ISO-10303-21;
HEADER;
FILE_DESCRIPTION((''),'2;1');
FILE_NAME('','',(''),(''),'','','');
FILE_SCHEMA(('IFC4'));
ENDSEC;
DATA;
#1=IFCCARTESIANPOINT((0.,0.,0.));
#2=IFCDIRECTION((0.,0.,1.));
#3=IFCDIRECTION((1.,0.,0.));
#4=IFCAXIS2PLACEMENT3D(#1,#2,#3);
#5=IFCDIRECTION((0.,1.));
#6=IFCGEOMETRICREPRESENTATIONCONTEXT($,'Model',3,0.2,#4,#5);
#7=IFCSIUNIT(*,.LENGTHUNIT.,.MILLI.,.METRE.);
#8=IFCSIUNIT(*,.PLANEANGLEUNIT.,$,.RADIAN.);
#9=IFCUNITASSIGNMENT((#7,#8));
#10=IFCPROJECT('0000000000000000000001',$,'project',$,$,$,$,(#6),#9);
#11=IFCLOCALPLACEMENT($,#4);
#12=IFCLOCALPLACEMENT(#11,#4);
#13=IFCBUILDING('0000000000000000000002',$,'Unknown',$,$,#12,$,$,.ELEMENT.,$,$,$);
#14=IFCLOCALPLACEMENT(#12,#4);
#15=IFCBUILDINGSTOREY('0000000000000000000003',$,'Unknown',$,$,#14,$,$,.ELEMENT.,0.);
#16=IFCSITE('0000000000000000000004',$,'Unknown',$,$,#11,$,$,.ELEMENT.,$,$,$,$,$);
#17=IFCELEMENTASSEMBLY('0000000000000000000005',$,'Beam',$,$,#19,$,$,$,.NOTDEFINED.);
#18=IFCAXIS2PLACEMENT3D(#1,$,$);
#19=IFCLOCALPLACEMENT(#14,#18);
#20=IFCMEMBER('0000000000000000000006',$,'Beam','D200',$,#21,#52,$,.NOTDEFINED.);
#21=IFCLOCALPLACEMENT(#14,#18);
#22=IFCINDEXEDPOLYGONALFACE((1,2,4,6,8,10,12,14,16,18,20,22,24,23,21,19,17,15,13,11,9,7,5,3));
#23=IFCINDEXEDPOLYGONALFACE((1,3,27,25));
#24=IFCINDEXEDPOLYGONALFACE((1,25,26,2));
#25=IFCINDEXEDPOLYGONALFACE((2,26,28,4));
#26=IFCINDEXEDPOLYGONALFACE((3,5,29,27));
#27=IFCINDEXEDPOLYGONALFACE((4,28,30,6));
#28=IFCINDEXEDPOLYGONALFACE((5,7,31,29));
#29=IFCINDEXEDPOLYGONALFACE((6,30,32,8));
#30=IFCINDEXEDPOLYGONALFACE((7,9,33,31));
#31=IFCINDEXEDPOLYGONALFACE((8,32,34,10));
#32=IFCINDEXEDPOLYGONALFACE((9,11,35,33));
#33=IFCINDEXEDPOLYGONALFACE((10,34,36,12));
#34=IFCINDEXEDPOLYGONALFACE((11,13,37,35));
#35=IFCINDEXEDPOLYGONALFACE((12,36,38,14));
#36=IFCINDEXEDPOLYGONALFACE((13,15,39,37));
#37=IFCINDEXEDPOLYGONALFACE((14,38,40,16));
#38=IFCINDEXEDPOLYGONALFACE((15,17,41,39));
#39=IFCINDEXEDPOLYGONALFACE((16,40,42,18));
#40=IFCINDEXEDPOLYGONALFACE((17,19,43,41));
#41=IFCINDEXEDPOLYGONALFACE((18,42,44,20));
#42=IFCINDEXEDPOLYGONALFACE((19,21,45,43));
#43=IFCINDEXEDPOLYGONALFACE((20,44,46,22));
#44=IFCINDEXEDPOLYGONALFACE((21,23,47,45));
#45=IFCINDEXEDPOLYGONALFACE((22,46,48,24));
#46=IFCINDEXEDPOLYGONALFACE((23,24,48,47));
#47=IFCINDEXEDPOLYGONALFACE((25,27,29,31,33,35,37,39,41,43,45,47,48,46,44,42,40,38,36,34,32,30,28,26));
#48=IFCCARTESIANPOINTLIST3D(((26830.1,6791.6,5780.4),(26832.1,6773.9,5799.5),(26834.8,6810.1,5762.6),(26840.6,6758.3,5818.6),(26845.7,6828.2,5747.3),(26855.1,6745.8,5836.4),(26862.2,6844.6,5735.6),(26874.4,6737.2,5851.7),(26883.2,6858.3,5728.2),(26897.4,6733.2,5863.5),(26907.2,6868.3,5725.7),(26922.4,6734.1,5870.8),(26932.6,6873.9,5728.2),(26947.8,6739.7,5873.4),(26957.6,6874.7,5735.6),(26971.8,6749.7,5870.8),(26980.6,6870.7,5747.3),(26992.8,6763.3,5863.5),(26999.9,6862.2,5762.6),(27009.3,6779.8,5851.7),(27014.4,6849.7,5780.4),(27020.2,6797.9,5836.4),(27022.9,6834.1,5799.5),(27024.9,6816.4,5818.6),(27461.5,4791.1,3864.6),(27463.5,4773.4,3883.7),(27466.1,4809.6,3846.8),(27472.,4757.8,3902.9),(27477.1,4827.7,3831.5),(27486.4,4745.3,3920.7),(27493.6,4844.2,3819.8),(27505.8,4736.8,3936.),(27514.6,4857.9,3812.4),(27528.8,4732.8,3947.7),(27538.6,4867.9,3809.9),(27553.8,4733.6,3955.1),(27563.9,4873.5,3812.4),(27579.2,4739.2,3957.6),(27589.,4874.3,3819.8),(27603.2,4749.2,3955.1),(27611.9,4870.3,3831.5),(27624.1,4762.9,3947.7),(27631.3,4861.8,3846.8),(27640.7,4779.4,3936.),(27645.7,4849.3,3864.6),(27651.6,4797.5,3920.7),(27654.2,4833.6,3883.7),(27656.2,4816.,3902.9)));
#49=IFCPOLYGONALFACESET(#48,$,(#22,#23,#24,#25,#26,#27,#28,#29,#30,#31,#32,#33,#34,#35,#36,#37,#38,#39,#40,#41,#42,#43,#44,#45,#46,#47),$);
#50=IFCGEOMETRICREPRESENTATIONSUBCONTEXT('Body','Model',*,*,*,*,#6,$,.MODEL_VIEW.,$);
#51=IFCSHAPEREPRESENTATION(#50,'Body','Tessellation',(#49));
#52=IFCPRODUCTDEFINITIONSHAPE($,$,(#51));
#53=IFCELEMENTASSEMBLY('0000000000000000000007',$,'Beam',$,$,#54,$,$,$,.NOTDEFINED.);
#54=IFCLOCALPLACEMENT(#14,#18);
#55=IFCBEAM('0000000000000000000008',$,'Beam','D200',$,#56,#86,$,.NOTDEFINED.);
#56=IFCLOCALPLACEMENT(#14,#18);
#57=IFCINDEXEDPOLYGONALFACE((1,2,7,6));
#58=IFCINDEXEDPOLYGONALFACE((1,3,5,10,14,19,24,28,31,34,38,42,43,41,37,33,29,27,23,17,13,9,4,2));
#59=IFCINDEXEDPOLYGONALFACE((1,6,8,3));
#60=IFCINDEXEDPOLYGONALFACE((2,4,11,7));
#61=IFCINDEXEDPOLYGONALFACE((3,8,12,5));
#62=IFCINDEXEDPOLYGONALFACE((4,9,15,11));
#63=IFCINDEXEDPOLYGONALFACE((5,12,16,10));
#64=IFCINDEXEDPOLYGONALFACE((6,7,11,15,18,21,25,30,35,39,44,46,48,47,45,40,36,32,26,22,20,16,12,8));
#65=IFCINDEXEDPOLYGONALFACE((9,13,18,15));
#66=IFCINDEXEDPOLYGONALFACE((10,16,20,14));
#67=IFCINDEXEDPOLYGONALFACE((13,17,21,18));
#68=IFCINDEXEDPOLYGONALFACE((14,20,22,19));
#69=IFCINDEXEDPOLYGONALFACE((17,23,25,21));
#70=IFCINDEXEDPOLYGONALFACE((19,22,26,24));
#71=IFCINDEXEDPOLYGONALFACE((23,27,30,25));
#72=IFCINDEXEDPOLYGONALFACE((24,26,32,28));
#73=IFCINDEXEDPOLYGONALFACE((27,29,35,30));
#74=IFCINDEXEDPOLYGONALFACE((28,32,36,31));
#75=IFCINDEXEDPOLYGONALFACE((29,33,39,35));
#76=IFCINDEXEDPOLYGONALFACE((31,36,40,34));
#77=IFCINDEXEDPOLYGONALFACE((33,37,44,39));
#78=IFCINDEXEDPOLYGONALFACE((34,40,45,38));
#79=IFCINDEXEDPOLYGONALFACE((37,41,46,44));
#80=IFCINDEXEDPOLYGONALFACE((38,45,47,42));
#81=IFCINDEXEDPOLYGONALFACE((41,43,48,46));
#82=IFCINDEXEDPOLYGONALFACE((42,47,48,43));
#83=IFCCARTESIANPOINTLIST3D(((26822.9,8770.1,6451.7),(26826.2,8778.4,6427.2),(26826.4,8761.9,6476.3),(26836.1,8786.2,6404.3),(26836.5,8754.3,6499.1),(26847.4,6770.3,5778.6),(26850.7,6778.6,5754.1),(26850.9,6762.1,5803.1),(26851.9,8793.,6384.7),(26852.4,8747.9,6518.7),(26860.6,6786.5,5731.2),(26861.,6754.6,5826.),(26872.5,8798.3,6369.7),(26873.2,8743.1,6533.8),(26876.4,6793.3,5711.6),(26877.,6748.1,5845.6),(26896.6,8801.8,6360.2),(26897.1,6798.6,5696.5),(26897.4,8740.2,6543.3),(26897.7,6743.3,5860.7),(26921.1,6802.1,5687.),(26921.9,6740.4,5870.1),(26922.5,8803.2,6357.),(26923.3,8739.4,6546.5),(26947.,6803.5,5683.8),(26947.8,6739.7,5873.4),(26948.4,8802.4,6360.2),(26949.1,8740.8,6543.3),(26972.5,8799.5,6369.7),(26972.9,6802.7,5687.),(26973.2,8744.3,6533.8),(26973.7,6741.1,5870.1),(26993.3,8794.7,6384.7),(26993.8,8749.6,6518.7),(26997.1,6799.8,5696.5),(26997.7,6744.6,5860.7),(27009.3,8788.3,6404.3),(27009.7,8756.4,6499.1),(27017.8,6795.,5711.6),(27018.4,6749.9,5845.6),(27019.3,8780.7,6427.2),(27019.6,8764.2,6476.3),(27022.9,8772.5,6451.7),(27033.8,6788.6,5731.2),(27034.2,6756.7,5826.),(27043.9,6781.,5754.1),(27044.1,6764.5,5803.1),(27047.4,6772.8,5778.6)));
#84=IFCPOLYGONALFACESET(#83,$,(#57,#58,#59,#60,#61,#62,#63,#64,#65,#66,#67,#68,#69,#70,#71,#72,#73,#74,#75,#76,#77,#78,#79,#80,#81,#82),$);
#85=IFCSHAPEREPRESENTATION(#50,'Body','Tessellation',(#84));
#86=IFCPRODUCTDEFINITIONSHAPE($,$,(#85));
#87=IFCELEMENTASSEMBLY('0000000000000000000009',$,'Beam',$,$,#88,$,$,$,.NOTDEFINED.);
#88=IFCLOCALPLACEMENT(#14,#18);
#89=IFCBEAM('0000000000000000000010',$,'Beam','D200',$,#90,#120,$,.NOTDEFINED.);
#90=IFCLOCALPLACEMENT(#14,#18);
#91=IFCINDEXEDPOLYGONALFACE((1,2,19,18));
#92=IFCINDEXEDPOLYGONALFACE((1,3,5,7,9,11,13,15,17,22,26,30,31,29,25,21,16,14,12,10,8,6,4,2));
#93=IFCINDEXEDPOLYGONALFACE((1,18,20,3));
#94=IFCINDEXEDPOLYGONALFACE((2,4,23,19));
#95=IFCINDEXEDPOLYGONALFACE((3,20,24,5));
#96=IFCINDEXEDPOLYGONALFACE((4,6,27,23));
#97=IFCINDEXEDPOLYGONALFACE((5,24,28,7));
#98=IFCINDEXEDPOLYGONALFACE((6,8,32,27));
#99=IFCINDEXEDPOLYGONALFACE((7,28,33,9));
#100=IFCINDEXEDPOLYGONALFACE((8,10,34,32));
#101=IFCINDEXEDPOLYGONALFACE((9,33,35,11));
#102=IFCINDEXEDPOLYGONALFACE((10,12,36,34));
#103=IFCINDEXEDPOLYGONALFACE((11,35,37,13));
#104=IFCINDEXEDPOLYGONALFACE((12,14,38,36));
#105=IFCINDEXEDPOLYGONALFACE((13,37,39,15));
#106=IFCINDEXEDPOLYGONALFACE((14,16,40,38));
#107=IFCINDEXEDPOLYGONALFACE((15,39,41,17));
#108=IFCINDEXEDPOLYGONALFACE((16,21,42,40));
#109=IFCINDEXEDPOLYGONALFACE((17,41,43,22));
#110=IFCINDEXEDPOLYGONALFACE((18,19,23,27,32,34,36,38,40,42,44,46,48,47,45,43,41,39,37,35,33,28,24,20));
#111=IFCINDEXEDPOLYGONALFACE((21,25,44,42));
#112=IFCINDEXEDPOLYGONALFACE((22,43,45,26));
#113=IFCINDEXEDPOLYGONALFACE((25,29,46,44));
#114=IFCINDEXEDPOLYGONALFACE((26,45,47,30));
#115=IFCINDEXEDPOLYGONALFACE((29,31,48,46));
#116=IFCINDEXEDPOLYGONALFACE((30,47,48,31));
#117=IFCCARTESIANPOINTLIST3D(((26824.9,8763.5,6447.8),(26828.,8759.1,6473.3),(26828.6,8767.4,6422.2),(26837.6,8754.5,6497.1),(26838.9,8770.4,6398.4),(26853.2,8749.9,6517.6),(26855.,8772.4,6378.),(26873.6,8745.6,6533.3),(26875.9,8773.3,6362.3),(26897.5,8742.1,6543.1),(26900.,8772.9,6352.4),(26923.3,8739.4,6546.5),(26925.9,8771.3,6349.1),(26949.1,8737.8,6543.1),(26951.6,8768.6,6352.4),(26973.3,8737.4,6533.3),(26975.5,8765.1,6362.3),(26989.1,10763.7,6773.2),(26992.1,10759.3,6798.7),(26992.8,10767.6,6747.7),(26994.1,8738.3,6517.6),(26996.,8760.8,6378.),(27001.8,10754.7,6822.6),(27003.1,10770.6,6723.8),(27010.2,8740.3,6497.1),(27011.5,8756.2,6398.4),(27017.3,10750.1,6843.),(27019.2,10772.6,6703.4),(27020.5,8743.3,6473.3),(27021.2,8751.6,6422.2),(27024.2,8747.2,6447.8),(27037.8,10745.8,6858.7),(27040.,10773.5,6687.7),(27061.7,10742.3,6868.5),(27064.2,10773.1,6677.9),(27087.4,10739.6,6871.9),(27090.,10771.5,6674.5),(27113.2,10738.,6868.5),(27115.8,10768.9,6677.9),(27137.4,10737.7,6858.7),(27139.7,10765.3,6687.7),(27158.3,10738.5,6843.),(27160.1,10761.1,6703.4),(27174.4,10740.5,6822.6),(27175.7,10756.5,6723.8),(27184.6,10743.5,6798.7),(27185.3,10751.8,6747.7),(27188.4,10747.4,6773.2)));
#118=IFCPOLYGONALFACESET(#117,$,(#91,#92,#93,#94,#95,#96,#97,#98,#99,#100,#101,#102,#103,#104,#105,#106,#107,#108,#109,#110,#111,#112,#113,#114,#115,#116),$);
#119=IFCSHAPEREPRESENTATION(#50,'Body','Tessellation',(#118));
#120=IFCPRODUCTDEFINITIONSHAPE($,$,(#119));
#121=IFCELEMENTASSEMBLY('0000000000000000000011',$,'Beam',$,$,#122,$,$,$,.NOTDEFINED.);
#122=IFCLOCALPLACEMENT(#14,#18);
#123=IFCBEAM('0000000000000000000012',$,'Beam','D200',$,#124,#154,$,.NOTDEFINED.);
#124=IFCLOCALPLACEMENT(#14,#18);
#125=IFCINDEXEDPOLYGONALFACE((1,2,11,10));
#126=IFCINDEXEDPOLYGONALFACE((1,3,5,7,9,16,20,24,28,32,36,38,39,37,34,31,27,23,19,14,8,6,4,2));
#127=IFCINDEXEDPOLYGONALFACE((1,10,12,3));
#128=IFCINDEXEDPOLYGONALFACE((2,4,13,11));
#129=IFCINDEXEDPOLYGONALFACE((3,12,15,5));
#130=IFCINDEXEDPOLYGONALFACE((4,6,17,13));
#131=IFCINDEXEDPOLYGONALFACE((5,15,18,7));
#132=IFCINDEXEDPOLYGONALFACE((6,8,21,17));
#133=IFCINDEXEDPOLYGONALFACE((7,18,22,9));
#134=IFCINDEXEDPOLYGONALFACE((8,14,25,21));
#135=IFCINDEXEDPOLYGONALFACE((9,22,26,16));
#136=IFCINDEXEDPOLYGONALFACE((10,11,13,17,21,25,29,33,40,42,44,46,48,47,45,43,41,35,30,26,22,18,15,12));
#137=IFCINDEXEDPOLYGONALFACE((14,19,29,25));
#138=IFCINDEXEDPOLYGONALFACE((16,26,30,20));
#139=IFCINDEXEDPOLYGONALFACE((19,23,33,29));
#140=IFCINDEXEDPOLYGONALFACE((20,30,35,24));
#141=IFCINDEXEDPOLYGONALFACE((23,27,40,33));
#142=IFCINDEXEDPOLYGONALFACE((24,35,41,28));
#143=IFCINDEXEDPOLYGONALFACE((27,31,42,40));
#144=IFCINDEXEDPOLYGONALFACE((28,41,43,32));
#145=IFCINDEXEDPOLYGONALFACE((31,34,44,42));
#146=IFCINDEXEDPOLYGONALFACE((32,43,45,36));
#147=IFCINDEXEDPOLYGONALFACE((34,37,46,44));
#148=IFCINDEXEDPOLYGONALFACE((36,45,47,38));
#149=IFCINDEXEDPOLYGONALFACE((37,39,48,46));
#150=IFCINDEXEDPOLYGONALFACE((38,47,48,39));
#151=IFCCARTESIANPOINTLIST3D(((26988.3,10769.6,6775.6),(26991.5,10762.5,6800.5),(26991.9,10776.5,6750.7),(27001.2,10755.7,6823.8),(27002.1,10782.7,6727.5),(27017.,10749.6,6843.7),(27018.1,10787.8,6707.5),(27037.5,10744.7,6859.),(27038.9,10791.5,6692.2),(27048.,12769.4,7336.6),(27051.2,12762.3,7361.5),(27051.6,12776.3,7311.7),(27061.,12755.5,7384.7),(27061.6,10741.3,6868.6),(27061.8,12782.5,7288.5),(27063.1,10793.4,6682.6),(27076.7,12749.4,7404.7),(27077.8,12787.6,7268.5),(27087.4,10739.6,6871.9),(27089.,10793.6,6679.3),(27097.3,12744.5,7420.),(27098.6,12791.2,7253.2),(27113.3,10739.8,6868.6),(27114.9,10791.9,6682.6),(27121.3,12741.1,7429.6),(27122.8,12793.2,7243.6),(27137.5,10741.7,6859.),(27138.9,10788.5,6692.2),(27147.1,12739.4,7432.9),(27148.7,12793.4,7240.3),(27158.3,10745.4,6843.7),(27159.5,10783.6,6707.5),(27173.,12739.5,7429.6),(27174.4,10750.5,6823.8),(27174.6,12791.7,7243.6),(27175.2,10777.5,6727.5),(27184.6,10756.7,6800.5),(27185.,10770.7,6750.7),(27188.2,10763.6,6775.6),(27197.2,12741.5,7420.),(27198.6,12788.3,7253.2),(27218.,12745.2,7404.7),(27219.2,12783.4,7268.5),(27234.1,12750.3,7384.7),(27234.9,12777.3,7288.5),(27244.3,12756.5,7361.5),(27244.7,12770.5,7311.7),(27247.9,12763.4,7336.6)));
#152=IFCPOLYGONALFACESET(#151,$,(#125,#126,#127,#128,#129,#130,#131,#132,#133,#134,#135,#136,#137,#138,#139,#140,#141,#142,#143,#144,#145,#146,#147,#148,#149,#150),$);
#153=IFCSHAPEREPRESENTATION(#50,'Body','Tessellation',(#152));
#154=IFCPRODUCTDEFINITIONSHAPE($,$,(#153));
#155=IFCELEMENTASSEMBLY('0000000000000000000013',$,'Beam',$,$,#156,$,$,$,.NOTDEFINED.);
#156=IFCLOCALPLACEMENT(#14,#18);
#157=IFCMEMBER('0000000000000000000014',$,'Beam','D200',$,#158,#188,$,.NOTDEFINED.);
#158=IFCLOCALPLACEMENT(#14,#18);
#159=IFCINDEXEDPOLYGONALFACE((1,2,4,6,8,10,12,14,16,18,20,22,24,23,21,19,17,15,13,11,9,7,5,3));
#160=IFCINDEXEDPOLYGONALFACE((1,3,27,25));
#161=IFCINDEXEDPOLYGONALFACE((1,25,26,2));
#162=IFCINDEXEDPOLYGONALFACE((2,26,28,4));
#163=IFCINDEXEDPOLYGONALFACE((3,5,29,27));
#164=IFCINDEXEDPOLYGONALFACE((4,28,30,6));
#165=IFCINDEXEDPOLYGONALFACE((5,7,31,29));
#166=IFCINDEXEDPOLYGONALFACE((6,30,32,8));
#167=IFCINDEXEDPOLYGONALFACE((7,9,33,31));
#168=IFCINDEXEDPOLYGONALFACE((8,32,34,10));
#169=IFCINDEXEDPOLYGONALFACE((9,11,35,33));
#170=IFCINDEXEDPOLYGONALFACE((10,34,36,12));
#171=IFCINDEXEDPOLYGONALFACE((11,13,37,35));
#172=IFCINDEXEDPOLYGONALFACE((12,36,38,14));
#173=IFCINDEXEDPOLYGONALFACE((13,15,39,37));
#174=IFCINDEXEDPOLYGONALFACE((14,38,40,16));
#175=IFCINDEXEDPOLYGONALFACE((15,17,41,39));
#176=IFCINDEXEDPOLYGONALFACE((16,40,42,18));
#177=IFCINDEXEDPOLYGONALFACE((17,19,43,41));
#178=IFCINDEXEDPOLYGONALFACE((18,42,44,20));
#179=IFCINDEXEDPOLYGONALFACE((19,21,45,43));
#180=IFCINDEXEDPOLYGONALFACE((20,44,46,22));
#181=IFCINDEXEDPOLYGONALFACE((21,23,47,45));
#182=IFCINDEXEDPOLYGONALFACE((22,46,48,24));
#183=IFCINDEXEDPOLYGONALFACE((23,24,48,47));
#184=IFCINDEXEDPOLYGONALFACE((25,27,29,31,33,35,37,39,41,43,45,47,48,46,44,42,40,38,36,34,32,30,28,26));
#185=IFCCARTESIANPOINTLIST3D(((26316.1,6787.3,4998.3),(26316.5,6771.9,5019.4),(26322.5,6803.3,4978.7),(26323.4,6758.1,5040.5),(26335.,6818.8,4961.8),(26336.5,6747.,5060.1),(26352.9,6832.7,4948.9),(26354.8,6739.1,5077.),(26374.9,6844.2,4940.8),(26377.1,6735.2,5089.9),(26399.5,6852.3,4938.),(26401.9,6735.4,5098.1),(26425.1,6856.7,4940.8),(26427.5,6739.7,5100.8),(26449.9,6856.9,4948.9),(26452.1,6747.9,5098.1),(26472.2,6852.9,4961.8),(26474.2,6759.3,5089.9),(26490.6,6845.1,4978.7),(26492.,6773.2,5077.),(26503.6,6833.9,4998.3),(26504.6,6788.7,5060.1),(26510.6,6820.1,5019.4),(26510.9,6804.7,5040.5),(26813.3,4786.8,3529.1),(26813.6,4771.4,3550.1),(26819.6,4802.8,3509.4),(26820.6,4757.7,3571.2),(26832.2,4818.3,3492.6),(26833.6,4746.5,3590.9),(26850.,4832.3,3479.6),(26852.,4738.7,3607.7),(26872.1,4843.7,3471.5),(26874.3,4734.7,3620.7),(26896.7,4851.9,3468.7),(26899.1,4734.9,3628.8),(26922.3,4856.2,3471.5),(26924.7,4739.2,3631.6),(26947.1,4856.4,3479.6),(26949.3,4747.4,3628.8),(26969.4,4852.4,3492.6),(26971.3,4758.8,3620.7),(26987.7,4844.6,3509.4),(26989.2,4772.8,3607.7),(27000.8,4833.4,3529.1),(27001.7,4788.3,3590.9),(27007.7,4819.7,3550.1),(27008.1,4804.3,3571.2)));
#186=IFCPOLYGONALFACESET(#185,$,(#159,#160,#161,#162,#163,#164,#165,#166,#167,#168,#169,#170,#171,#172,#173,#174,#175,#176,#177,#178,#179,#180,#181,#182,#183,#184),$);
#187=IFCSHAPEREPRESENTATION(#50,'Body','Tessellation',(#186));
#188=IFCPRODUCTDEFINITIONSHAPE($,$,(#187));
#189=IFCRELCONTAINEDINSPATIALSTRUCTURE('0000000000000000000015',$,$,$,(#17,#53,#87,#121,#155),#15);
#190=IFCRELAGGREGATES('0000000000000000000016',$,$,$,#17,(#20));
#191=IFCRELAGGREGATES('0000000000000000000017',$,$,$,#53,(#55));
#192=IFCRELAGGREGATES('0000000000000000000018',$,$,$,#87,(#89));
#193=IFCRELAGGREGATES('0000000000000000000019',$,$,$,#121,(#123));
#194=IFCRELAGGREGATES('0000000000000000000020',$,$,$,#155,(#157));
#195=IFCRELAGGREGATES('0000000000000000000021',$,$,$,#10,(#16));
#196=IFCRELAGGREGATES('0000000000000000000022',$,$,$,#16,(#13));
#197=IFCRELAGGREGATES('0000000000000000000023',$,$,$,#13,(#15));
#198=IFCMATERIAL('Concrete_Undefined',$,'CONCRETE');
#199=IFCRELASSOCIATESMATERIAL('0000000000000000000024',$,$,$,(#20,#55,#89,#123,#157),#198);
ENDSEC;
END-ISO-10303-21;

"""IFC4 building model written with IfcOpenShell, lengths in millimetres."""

from ifc_helpers import new_model, si_unit, direction, frame, origin_with_axes, place, context, subcontext, project, spatial, line, indexed_curve, outline, extrude, material, element, aggregate, save


model = new_model("IFC4")

# Units and contexts
model_context = context("Model", 3, precision=0.2, world=origin_with_axes(), true_north=direction((0.0, 1.0)))
body_context = subcontext(model_context, "Body", "Model", "MODEL_VIEW")
ifc_project = project(units=[si_unit("LENGTHUNIT", "METRE", prefix="MILLI"), si_unit("PLANEANGLEUNIT", "RADIAN")], contexts=[model_context])

# Site, building, storey
site_placement = place(None, origin_with_axes())
site = spatial("IfcSite", under=ifc_project, at=site_placement, Name="Unknown", CompositionType="ELEMENT")
building_placement = place(site_placement, origin_with_axes())
building = spatial("IfcBuilding", under=site, at=building_placement, Name="Unknown", CompositionType="ELEMENT")
storey_placement = place(building_placement, origin_with_axes())
storey = spatial("IfcBuildingStorey", under=building, at=storey_placement, Name="Unknown", CompositionType="ELEMENT", Elevation=0.0)

# Shared definitions
ifc_material = material(Name="Concrete_Undefined", Category="CONCRETE")

# Element assembly, member
assembly_1_placement = place(storey_placement, frame((26927.5, 6804.0, 5799.5), z_axis=(-0.953629, -0.300984, 0.0), x_axis=(0.222248, -0.704163, -0.67436)))
assembly_1 = element("IfcElementAssembly", 1, at=assembly_1_placement, inside=storey, Name="Beam", PredefinedType="NOTDEFINED")
member_1_placement = place(assembly_1_placement, origin_with_axes())
member_1 = element("IfcMember", 2, at=member_1_placement, material=ifc_material, Name="Beam", Description="D200", PredefinedType="NOTDEFINED", context=body_context, shape_type="SolidModel", body=[
    extrude(outline(indexed_curve([(100.0, 0.0), (96.6, 25.9), (86.6, 50.0), (70.7, 70.7), (50.0, 86.6), (25.9, 96.6), (0.0, 100.0), (-25.9, 96.6), (-50.0, 86.6), (-70.7, 70.7), (-86.6, 50.0), (-96.6, 25.9), (-100.0, 0.0), (-96.6, -25.9), (-86.6, -50.0), (-70.7, -70.7), (-50.0, -86.6), (-25.9, -96.6), (0.0, -100.0), (25.9, -96.6), (50.0, -86.6), (70.7, -70.7), (86.6, -50.0), (96.6, -25.9)], segments=[line(1, 2, 3, 4, 5, 6, 7, 8, 9, 10, 11, 12, 13, 14, 15, 16, 17, 18, 19, 20, 21, 22, 23, 24, 1)])), frame((0.0, 0.0, 0.0), z_axis=(-1.0, 0.0, 0.0), x_axis=(0.0, 0.0, 1.0)), (0.0, 0.0, -1.0), 2840.9),
])
aggregate(assembly_1, [member_1])

# Element assemblies, beams
assembly_2_placement = place(storey_placement, frame((26922.9, 8771.3, 6451.7), z_axis=(-0.999925, -0.012268, 0.0), x_axis=(0.011627, -0.947681, -0.319006)))
assembly_2 = element("IfcElementAssembly", 3, at=assembly_2_placement, inside=storey, Name="Beam", PredefinedType="NOTDEFINED")
beam_1_placement = place(assembly_2_placement, origin_with_axes())
beam_1 = element("IfcBeam", 4, at=beam_1_placement, material=ifc_material, Name="Beam", Description="D200", PredefinedType="NOTDEFINED", context=body_context, shape_type="SolidModel", body=[
    extrude(outline(indexed_curve([(100.0, 0.0), (96.6, 25.9), (86.6, 50.0), (70.7, 70.7), (50.0, 86.6), (25.9, 96.6), (0.0, 100.0), (-25.9, 96.6), (-50.0, 86.6), (-70.7, 70.7), (-86.6, 50.0), (-96.6, 25.9), (-100.0, 0.0), (-96.6, -25.9), (-86.6, -50.0), (-70.7, -70.7), (-50.0, -86.6), (-25.9, -96.6), (0.0, -100.0), (25.9, -96.6), (50.0, -86.6), (70.7, -70.7), (86.6, -50.0), (96.6, -25.9)], segments=[line(1, 2, 3, 4, 5, 6, 7, 8, 9, 10, 11, 12, 13, 14, 15, 16, 17, 18, 19, 20, 21, 22, 23, 24, 1)])), frame((0.0, 0.0, 0.0), z_axis=(-1.0, 0.0, 0.0), x_axis=(0.0, 0.0, 1.0)), (0.0, 0.0, -1.0), 2110.1),
])
aggregate(assembly_2, [beam_1])
assembly_3_placement = place(storey_placement, frame((27088.7, 10755.6, 6773.2), z_axis=(-0.996649, 0.081793, 0.0), x_axis=(-0.080738, -0.983801, -0.160051)))
assembly_3 = element("IfcElementAssembly", 5, at=assembly_3_placement, inside=storey, Name="Beam", PredefinedType="NOTDEFINED")
beam_2_placement = place(assembly_3_placement, origin_with_axes())
beam_2 = element("IfcBeam", 6, at=beam_2_placement, material=ifc_material, Name="Beam", Description="D200", PredefinedType="NOTDEFINED", context=body_context, shape_type="SolidModel", body=[
    extrude(outline(indexed_curve([(100.0, 0.0), (96.6, 25.9), (86.6, 50.0), (70.7, 70.7), (50.0, 86.6), (25.9, 96.6), (0.0, 100.0), (-25.9, 96.6), (-50.0, 86.6), (-70.7, 70.7), (-86.6, 50.0), (-96.6, 25.9), (-100.0, 0.0), (-96.6, -25.9), (-86.6, -50.0), (-70.7, -70.7), (-50.0, -86.6), (-25.9, -96.6), (0.0, -100.0), (25.9, -96.6), (50.0, -86.6), (70.7, -70.7), (86.6, -50.0), (96.6, -25.9)], segments=[line(1, 2, 3, 4, 5, 6, 7, 8, 9, 10, 11, 12, 13, 14, 15, 16, 17, 18, 19, 20, 21, 22, 23, 24, 1)])), frame((0.0, 0.0, 0.0), z_axis=(-1.0, 0.0, 0.0), x_axis=(0.0, 0.0, 1.0)), (0.0, 0.0, -1.0), 2033.1),
])
aggregate(assembly_3, [beam_2])
assembly_4_placement = place(storey_placement, frame((27147.9, 12766.4, 7336.6), z_axis=(-0.999555, 0.029845, 0.0), x_axis=(-0.028737, -0.962436, -0.269982)))
assembly_4 = element("IfcElementAssembly", 7, at=assembly_4_placement, inside=storey, Name="Beam", PredefinedType="NOTDEFINED")
beam_3_placement = place(assembly_4_placement, origin_with_axes())
beam_3 = element("IfcBeam", 8, at=beam_3_placement, material=ifc_material, Name="Beam", Description="D200", PredefinedType="NOTDEFINED", context=body_context, shape_type="SolidModel", body=[
    extrude(outline(indexed_curve([(100.0, 0.0), (96.6, 25.9), (86.6, 50.0), (70.7, 70.7), (50.0, 86.6), (25.9, 96.6), (0.0, 100.0), (-25.9, 96.6), (-50.0, 86.6), (-70.7, 70.7), (-86.6, 50.0), (-96.6, 25.9), (-100.0, 0.0), (-96.6, -25.9), (-86.6, -50.0), (-70.7, -70.7), (-50.0, -86.6), (-25.9, -96.6), (0.0, -100.0), (25.9, -96.6), (50.0, -86.6), (70.7, -70.7), (86.6, -50.0), (96.6, -25.9)], segments=[line(1, 2, 3, 4, 5, 6, 7, 8, 9, 10, 11, 12, 13, 14, 15, 16, 17, 18, 19, 20, 21, 22, 23, 24, 1)])), frame((0.0, 0.0, 0.0), z_axis=(-1.0, 0.0, 0.0), x_axis=(0.0, 0.0, 1.0)), (0.0, 0.0, -1.0), 2077.8),
])
aggregate(assembly_4, [beam_3])

# Element assembly, member
assembly_5_placement = place(storey_placement, frame((26413.5, 6796.0, 5019.4), z_axis=(-0.970475, -0.2412, 0.0), x_axis=(0.196412, -0.79027, -0.580428)))
assembly_5 = element("IfcElementAssembly", 9, at=assembly_5_placement, inside=storey, Name="Beam", PredefinedType="NOTDEFINED")
member_2_placement = place(assembly_5_placement, origin_with_axes())
member_2 = element("IfcMember", 10, at=member_2_placement, material=ifc_material, Name="Beam", Description="D200", PredefinedType="NOTDEFINED", context=body_context, shape_type="SolidModel", body=[
    extrude(outline(indexed_curve([(100.0, 0.0), (96.6, 25.9), (86.6, 50.0), (70.7, 70.7), (50.0, 86.6), (25.9, 96.6), (0.0, 100.0), (-25.9, 96.6), (-50.0, 86.6), (-70.7, 70.7), (-86.6, 50.0), (-96.6, 25.9), (-100.0, 0.0), (-96.6, -25.9), (-86.6, -50.0), (-70.7, -70.7), (-50.0, -86.6), (-25.9, -96.6), (0.0, -100.0), (25.9, -96.6), (50.0, -86.6), (70.7, -70.7), (86.6, -50.0), (96.6, -25.9)], segments=[line(1, 2, 3, 4, 5, 6, 7, 8, 9, 10, 11, 12, 13, 14, 15, 16, 17, 18, 19, 20, 21, 22, 23, 24, 1)])), frame((0.0, 0.0, 0.0), z_axis=(-1.0, 0.0, 0.0), x_axis=(0.0, 0.0, 1.0)), (0.0, 0.0, -1.0), 2531.4),
])
aggregate(assembly_5, [member_2])

save(model, "model.ifc")
